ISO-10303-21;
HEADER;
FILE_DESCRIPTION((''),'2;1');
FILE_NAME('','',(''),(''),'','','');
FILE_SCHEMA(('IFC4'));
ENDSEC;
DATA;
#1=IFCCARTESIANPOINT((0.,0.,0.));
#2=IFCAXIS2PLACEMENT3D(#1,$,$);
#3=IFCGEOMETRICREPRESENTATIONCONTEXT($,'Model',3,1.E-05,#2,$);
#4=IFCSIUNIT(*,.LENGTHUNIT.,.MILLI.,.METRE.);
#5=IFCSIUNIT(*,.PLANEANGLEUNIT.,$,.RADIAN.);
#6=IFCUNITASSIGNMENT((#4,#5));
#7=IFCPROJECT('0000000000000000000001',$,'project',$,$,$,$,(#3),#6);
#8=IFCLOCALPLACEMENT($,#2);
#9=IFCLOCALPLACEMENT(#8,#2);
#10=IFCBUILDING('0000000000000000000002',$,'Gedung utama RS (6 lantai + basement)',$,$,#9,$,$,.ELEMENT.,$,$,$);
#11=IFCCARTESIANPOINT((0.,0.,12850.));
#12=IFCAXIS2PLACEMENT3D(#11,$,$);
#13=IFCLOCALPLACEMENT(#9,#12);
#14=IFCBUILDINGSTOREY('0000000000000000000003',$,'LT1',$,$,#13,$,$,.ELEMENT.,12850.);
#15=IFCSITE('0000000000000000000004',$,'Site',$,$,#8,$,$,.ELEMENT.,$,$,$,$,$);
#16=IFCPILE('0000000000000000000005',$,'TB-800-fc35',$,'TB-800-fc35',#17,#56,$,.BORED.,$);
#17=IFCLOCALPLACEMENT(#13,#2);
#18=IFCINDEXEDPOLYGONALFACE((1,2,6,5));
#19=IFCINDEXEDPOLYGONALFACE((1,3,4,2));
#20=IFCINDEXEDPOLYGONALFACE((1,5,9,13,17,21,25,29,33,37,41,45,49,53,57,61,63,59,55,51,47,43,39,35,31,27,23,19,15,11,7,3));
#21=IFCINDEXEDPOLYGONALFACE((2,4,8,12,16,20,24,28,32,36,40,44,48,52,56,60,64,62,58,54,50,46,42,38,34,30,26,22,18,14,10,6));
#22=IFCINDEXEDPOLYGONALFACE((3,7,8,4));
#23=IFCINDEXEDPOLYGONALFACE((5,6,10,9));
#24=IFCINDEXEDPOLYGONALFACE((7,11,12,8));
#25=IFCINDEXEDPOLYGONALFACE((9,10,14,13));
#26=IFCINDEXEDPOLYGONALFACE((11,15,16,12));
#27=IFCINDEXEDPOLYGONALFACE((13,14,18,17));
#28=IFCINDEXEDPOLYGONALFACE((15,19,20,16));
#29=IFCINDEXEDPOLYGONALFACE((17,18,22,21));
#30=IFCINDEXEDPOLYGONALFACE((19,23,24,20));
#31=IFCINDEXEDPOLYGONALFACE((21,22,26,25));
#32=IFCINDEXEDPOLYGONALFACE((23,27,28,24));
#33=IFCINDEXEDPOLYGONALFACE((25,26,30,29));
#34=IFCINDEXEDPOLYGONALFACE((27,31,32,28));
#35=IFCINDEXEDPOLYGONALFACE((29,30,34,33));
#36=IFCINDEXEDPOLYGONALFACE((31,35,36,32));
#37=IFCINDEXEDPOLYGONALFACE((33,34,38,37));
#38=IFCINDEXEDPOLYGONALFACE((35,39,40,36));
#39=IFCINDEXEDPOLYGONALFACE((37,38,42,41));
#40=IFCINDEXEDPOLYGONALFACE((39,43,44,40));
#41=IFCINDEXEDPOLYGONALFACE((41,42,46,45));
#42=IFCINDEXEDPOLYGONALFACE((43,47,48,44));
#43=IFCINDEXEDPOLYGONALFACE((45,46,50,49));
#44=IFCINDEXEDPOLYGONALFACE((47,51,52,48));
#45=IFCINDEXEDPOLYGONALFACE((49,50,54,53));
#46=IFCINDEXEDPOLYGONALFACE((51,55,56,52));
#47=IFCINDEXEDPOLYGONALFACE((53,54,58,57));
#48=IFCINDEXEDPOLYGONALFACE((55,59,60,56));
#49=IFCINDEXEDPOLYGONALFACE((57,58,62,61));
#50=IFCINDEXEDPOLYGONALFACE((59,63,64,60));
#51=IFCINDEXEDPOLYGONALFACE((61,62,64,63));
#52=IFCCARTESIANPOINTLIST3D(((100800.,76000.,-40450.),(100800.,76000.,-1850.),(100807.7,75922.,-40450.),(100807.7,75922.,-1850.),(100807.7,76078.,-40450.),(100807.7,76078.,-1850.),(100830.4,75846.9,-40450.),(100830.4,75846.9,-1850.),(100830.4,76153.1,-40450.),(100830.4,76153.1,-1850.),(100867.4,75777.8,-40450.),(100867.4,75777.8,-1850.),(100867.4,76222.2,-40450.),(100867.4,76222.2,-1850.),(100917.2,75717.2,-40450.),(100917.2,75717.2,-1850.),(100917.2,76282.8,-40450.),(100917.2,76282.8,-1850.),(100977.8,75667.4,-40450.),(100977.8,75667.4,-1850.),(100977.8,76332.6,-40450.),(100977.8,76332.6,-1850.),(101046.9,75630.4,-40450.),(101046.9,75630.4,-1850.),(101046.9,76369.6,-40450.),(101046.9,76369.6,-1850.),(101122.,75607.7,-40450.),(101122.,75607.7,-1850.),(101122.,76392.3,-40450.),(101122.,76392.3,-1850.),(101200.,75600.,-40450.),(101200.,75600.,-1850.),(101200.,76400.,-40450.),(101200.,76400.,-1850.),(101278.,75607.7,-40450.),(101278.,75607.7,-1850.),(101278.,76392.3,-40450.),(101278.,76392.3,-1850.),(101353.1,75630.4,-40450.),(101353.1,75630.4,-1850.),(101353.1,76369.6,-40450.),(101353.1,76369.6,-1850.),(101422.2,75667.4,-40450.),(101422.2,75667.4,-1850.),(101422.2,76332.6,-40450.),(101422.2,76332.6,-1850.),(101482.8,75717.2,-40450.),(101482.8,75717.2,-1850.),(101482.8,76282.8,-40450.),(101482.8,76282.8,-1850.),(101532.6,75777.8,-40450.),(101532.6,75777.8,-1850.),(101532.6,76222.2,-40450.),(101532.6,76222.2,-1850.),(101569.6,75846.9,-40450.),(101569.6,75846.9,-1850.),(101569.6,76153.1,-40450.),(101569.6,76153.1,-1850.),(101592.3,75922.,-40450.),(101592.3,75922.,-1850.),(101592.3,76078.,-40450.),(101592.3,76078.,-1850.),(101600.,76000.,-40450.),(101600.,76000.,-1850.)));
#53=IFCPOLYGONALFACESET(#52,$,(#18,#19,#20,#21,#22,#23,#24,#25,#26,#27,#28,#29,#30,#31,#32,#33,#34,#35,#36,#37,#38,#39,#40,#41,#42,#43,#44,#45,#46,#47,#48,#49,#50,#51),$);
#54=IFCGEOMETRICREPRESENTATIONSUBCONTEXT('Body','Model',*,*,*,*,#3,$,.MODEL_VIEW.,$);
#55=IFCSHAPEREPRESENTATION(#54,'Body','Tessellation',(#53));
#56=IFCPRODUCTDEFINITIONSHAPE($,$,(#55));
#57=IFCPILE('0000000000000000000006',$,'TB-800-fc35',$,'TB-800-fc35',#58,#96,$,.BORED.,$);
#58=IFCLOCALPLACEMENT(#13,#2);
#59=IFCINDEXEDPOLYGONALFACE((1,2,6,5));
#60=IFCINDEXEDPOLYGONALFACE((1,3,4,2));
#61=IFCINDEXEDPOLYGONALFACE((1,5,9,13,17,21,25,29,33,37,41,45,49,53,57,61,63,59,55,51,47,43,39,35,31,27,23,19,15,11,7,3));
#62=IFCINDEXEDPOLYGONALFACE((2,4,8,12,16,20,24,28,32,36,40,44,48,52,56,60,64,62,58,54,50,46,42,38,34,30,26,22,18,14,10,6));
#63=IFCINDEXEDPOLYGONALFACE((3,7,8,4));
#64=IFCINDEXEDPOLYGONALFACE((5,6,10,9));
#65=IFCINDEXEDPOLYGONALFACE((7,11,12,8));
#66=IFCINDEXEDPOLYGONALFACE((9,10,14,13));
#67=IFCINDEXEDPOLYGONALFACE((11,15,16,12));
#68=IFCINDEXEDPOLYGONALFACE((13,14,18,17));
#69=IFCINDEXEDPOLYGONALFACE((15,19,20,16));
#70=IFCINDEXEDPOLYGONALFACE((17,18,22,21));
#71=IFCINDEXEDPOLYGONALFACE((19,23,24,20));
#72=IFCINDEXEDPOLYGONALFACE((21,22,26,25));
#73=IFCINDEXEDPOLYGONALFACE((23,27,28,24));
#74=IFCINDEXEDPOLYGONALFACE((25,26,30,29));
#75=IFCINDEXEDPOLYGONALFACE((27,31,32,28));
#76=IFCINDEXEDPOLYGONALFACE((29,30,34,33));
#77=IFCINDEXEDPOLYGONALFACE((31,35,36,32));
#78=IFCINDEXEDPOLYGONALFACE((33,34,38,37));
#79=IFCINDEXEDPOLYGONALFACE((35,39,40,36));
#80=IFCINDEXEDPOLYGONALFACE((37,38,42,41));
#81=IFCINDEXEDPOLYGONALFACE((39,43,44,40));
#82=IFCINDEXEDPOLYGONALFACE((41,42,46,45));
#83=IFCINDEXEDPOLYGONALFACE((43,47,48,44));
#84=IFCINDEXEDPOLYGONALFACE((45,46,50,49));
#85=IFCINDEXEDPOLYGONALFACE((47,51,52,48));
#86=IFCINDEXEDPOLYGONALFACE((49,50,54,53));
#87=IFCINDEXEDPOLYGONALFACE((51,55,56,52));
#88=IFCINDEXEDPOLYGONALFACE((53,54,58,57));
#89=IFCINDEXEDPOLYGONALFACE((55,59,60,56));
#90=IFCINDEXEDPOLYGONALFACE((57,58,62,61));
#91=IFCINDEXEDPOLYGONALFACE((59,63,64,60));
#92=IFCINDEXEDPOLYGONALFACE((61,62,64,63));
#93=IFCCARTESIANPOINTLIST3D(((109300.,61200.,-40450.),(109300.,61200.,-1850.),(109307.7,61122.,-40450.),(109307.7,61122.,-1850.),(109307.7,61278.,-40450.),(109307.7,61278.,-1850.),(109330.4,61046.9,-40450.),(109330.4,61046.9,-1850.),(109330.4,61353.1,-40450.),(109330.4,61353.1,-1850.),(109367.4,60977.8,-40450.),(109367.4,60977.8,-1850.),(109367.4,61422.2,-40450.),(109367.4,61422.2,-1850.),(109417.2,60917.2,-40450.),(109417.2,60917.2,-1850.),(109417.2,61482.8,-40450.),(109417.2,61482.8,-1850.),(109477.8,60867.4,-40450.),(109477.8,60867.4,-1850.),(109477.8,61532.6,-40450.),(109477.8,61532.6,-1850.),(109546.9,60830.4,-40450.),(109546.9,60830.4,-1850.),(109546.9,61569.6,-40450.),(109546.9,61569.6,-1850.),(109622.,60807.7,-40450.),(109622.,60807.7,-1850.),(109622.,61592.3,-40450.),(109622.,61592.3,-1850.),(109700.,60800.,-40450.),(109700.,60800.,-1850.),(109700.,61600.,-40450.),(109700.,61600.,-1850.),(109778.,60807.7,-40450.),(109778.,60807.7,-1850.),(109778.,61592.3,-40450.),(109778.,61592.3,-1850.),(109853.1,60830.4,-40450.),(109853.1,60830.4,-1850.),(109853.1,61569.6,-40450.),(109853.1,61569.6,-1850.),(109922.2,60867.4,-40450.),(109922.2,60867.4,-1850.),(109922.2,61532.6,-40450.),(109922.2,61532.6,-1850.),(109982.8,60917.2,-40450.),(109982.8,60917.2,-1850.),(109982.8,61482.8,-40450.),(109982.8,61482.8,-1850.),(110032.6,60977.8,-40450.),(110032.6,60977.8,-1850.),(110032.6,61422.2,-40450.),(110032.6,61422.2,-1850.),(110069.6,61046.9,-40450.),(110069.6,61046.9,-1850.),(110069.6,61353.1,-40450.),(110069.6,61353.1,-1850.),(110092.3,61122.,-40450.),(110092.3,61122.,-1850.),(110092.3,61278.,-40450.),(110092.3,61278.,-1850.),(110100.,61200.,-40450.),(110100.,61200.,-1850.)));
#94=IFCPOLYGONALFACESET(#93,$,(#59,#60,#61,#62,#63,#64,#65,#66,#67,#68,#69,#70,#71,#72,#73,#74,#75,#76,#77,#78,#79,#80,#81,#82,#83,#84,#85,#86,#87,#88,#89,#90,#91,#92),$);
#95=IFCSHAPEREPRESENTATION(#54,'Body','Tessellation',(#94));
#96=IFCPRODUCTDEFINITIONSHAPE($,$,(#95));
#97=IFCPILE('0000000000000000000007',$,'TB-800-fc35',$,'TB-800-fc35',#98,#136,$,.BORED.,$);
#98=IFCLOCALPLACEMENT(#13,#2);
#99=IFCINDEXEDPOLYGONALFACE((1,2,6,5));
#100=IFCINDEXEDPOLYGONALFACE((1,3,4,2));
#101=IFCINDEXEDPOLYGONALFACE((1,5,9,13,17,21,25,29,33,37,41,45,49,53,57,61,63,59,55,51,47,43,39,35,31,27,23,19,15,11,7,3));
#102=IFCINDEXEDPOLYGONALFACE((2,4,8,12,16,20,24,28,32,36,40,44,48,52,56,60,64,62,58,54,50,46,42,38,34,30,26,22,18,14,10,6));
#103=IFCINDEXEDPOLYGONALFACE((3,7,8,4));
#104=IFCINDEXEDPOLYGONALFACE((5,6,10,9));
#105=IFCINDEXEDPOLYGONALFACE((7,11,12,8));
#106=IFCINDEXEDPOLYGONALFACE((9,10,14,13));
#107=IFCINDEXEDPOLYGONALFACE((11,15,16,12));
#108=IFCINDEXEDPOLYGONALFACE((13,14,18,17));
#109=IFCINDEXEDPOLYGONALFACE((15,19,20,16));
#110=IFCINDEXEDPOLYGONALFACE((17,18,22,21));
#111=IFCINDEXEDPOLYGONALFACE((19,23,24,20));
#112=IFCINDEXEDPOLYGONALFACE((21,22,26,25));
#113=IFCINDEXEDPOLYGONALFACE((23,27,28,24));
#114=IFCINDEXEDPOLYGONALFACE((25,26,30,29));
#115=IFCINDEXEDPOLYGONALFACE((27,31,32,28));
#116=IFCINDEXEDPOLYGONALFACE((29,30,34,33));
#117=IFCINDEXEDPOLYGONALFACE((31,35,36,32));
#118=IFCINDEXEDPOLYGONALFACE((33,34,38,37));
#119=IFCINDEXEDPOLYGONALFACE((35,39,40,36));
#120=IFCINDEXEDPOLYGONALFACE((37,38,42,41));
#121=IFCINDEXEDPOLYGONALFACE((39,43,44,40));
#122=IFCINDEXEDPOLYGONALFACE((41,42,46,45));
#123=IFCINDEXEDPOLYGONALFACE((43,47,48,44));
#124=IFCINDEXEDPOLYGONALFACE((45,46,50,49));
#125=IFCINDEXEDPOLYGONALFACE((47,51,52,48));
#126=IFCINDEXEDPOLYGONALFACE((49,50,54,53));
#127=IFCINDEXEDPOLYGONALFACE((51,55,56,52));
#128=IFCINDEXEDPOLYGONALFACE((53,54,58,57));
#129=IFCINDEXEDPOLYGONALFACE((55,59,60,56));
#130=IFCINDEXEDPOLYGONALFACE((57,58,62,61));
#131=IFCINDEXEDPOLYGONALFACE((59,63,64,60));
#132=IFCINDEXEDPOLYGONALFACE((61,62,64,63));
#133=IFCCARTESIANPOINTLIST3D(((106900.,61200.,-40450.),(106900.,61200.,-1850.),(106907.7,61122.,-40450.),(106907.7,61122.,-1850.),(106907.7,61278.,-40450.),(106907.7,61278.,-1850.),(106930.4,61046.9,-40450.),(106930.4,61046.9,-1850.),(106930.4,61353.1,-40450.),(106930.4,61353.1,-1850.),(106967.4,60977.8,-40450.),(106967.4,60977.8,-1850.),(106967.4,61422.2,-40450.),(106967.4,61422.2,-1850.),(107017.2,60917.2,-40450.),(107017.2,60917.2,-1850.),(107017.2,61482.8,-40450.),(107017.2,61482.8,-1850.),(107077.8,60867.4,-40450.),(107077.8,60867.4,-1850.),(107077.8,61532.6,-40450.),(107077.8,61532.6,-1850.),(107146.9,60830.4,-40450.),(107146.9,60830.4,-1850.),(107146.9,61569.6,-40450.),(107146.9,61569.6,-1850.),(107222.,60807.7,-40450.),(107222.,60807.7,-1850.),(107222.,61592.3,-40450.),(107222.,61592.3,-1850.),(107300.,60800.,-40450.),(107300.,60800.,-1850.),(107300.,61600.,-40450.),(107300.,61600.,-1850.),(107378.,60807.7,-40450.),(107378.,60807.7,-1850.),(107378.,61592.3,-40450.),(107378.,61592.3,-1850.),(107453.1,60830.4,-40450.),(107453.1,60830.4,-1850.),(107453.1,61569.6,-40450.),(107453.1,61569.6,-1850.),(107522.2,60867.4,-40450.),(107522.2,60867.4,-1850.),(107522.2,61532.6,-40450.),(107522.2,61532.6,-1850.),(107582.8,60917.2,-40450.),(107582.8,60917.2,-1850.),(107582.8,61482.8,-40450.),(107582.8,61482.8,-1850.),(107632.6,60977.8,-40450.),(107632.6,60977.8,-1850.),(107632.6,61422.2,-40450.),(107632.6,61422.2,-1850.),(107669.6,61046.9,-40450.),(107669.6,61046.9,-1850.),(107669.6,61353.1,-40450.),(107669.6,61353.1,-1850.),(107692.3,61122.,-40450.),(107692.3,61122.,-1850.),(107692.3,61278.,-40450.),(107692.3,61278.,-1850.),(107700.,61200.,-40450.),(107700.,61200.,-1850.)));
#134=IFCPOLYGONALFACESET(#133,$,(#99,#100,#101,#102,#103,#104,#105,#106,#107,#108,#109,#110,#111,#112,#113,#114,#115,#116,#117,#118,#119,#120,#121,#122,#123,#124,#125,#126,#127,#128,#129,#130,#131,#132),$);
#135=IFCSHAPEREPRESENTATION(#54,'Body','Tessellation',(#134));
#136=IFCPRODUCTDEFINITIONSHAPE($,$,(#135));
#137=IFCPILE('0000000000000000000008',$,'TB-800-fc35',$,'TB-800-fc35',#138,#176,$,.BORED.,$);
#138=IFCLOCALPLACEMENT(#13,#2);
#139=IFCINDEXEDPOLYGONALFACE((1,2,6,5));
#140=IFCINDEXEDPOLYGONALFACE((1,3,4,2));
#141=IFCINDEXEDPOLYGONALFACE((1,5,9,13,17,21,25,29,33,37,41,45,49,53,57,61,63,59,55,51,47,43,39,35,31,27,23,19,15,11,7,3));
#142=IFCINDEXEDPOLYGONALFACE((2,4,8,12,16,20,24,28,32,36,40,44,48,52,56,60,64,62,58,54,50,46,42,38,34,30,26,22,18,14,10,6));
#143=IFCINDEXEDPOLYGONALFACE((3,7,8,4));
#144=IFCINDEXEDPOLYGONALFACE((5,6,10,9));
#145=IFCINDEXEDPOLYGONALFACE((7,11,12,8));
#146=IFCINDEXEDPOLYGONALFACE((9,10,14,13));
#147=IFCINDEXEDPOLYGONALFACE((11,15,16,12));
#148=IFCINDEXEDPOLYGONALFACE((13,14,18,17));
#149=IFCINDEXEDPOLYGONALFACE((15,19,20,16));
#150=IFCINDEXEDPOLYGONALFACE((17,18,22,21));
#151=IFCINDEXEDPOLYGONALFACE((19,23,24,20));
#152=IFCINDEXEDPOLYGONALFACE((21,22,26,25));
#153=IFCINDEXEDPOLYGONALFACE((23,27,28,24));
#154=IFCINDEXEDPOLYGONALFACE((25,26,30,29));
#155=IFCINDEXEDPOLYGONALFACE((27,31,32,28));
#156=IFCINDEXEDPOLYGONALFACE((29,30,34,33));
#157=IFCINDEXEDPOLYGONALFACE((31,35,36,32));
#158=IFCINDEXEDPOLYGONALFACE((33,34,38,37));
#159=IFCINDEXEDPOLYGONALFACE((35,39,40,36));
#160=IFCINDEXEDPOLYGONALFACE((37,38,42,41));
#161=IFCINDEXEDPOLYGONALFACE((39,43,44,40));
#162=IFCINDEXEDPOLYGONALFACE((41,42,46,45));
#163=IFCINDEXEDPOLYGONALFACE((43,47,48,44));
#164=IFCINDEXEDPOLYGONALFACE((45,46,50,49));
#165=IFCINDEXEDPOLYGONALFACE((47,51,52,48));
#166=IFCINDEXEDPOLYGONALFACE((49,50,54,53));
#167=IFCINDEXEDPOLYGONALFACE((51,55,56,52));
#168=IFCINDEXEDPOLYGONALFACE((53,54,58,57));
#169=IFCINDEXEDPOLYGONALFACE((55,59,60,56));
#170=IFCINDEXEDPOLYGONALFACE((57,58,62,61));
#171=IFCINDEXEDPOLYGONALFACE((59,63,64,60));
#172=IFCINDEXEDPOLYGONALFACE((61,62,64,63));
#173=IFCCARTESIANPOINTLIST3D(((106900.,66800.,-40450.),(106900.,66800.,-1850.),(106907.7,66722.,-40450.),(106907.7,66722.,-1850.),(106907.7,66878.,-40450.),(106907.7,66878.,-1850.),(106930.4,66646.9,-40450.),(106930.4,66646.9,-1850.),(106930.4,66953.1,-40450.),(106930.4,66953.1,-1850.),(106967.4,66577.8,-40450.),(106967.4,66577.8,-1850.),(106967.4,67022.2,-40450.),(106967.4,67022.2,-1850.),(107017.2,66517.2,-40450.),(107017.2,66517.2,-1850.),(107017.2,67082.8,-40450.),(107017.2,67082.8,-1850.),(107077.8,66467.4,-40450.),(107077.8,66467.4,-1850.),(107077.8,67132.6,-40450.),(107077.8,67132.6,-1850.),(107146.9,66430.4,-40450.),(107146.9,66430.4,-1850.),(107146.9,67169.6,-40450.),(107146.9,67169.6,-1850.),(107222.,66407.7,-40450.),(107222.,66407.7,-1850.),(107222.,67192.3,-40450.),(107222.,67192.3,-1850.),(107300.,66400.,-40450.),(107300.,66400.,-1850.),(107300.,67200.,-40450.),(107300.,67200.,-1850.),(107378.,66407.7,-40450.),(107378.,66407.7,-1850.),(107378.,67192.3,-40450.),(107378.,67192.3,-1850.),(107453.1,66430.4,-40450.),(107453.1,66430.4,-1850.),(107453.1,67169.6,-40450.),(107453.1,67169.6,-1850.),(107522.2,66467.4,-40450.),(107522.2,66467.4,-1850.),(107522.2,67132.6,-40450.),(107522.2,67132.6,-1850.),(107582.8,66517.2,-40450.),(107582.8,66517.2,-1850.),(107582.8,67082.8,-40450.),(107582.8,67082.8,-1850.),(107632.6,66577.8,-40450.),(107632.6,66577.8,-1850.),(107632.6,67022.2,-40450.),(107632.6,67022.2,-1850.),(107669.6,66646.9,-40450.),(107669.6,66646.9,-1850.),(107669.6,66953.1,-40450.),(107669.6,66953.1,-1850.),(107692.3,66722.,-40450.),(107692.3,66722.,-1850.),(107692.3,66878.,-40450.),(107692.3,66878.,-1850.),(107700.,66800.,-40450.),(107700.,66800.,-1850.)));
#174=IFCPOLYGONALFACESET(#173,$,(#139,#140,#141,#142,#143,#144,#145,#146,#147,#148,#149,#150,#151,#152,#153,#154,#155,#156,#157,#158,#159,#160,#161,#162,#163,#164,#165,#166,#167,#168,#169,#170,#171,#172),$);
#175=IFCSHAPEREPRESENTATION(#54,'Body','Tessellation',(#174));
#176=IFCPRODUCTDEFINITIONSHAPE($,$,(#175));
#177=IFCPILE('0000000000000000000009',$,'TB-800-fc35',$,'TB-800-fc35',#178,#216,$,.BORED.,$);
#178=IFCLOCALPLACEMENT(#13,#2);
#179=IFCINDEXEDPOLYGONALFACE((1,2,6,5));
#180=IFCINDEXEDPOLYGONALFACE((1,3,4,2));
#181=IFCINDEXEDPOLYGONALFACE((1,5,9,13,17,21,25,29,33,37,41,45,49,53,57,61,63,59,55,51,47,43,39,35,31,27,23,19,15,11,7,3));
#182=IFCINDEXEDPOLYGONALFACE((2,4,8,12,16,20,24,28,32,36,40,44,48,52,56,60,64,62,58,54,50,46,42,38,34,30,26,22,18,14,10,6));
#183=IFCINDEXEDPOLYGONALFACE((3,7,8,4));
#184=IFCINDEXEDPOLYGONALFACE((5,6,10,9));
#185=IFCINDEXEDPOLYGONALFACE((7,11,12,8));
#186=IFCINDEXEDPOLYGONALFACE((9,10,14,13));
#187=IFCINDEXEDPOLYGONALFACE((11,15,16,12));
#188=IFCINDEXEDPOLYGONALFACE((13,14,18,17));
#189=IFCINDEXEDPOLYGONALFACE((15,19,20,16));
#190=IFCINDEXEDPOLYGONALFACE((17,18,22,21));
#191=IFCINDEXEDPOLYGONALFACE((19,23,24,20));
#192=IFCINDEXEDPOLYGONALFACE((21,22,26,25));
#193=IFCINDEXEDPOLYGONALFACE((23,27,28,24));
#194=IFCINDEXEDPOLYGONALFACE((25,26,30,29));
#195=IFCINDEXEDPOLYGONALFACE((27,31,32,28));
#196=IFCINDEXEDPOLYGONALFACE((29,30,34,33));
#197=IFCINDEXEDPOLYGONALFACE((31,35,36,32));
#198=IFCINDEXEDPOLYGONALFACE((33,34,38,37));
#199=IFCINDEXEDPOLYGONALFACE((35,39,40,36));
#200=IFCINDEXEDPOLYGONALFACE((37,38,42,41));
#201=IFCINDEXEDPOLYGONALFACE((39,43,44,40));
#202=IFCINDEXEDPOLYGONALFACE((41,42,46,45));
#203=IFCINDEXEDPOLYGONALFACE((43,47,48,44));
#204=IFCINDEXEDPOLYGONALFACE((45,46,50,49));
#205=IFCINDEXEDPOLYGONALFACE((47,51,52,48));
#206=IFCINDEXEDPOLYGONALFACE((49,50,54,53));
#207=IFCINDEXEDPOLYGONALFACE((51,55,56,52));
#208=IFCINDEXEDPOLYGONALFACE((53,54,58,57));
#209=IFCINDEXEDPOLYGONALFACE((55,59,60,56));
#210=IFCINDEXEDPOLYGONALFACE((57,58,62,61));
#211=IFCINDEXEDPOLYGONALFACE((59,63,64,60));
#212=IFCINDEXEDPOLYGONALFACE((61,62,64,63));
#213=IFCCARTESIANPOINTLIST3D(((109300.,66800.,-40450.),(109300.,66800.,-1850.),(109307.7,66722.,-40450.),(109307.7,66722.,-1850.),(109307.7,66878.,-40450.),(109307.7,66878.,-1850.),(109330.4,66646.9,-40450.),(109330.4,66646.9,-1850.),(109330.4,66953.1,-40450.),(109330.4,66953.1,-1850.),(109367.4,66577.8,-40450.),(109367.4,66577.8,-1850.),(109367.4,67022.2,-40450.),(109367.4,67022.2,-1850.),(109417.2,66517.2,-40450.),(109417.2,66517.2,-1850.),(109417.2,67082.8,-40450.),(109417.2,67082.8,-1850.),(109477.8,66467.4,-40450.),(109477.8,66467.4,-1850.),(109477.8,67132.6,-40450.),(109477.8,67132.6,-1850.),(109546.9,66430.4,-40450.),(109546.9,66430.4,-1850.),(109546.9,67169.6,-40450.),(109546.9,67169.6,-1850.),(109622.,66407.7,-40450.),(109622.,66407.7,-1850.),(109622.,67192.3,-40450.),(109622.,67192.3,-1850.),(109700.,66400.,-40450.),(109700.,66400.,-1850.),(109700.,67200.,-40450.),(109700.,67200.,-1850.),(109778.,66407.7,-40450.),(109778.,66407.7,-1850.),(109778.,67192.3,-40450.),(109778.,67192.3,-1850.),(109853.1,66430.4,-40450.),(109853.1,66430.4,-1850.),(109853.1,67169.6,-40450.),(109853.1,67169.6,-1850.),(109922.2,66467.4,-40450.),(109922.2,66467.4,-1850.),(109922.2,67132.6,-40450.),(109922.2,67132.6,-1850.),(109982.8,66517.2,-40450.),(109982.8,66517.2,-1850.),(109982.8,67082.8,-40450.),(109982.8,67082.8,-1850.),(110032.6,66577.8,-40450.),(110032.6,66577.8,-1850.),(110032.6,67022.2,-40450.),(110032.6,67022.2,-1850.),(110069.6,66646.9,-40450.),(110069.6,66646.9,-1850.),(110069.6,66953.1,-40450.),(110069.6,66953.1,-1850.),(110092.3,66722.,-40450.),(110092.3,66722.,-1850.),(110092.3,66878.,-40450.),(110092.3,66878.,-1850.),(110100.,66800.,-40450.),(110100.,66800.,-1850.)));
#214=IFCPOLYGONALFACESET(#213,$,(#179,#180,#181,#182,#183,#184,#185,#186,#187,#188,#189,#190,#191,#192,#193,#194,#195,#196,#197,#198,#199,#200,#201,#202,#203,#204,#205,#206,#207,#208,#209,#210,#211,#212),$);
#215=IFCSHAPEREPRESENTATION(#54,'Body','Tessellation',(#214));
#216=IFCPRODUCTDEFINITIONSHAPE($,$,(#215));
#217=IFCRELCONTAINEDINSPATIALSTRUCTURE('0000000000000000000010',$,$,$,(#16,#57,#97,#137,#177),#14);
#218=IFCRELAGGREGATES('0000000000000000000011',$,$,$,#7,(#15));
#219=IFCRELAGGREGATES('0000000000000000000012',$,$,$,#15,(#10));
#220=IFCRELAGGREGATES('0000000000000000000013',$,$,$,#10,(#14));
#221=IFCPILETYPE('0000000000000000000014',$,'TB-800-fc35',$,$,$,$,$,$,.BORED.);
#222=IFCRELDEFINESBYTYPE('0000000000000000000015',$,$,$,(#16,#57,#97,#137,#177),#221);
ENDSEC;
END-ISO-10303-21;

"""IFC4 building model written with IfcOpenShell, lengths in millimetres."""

from ifc_helpers import new_model, si_unit, frame, origin, origin_2d, place, context, subcontext, project, spatial, circle, extrude, material_profile, profile_set, profile_usage, type_object, element, save


model = new_model("IFC4")

# Units and contexts
model_context = context("Model", 3, precision=1e-05, world=origin())
body_context = subcontext(model_context, "Body", "Model", "MODEL_VIEW")
ifc_project = project(units=[si_unit("LENGTHUNIT", "METRE", prefix="MILLI"), si_unit("PLANEANGLEUNIT", "RADIAN")], contexts=[model_context])

# Site, building, storey
site_placement = place(None, origin())
site = spatial("IfcSite", under=ifc_project, at=site_placement, Name="Site", CompositionType="ELEMENT")
building_placement = place(site_placement, origin())
building = spatial("IfcBuilding", under=site, at=building_placement, Name="Gedung utama RS (6 lantai + basement)", CompositionType="ELEMENT")
storey_placement = place(building_placement, frame((0.0, 0.0, 12850.0)))
storey = spatial("IfcBuildingStorey", under=building, at=storey_placement, Name="LT1", CompositionType="ELEMENT", Elevation=12850.0)

# Piles
ifc_material_profile = material_profile(None, circle(Radius=400.0, at=origin_2d()), Name="TB-800-fc35")
ifc_profile_set = profile_set([ifc_material_profile], Name="TB-800-fc35")
ifc_profile_usage = profile_usage(ifc_profile_set, cardinal=5)
pile_type = type_object("IfcPileType", Name="TB-800-fc35", PredefinedType="BORED", material=ifc_profile_set)
for number, where, z_axis, x_axis, name in (
    (1, (101200.0, 76000.0, -40450.0), (0.0, 0.0, 1.0), (1.0, 0.0, 0.0), "TB-800-fc35"),
    (2, (109700.0, 61200.0, -40450.0), (0.0, 0.0, 1.0), (1.0, 0.0, 0.0), "TB-800-fc35"),
    (3, (107300.0, 61200.0, -40450.0), (0.0, 0.0, 1.0), (1.0, 0.0, 0.0), "TB-800-fc35"),
    (4, (107300.0, 66800.0, -40450.0), (0.0, 0.0, 1.0), (1.0, 0.0, 0.0), "TB-800-fc35"),
    (5, (109700.0, 66800.0, -40450.0), (0.0, 0.0, 1.0), (1.0, 0.0, 0.0), "TB-800-fc35"),
):
    element("IfcPile", number, at=place(storey_placement, frame(where, z_axis=z_axis, x_axis=x_axis)), inside=storey, type_object=pile_type, material=ifc_profile_usage, Name=name, ObjectType="TB-800-fc35", PredefinedType="BORED", context=body_context, shape_type="SweptSolid", body=[
        extrude(circle(Radius=400.0, at=origin_2d()), origin(), (0.0, 0.0, 1.0), 38600.0),
    ])

save(model, "model.ifc")
